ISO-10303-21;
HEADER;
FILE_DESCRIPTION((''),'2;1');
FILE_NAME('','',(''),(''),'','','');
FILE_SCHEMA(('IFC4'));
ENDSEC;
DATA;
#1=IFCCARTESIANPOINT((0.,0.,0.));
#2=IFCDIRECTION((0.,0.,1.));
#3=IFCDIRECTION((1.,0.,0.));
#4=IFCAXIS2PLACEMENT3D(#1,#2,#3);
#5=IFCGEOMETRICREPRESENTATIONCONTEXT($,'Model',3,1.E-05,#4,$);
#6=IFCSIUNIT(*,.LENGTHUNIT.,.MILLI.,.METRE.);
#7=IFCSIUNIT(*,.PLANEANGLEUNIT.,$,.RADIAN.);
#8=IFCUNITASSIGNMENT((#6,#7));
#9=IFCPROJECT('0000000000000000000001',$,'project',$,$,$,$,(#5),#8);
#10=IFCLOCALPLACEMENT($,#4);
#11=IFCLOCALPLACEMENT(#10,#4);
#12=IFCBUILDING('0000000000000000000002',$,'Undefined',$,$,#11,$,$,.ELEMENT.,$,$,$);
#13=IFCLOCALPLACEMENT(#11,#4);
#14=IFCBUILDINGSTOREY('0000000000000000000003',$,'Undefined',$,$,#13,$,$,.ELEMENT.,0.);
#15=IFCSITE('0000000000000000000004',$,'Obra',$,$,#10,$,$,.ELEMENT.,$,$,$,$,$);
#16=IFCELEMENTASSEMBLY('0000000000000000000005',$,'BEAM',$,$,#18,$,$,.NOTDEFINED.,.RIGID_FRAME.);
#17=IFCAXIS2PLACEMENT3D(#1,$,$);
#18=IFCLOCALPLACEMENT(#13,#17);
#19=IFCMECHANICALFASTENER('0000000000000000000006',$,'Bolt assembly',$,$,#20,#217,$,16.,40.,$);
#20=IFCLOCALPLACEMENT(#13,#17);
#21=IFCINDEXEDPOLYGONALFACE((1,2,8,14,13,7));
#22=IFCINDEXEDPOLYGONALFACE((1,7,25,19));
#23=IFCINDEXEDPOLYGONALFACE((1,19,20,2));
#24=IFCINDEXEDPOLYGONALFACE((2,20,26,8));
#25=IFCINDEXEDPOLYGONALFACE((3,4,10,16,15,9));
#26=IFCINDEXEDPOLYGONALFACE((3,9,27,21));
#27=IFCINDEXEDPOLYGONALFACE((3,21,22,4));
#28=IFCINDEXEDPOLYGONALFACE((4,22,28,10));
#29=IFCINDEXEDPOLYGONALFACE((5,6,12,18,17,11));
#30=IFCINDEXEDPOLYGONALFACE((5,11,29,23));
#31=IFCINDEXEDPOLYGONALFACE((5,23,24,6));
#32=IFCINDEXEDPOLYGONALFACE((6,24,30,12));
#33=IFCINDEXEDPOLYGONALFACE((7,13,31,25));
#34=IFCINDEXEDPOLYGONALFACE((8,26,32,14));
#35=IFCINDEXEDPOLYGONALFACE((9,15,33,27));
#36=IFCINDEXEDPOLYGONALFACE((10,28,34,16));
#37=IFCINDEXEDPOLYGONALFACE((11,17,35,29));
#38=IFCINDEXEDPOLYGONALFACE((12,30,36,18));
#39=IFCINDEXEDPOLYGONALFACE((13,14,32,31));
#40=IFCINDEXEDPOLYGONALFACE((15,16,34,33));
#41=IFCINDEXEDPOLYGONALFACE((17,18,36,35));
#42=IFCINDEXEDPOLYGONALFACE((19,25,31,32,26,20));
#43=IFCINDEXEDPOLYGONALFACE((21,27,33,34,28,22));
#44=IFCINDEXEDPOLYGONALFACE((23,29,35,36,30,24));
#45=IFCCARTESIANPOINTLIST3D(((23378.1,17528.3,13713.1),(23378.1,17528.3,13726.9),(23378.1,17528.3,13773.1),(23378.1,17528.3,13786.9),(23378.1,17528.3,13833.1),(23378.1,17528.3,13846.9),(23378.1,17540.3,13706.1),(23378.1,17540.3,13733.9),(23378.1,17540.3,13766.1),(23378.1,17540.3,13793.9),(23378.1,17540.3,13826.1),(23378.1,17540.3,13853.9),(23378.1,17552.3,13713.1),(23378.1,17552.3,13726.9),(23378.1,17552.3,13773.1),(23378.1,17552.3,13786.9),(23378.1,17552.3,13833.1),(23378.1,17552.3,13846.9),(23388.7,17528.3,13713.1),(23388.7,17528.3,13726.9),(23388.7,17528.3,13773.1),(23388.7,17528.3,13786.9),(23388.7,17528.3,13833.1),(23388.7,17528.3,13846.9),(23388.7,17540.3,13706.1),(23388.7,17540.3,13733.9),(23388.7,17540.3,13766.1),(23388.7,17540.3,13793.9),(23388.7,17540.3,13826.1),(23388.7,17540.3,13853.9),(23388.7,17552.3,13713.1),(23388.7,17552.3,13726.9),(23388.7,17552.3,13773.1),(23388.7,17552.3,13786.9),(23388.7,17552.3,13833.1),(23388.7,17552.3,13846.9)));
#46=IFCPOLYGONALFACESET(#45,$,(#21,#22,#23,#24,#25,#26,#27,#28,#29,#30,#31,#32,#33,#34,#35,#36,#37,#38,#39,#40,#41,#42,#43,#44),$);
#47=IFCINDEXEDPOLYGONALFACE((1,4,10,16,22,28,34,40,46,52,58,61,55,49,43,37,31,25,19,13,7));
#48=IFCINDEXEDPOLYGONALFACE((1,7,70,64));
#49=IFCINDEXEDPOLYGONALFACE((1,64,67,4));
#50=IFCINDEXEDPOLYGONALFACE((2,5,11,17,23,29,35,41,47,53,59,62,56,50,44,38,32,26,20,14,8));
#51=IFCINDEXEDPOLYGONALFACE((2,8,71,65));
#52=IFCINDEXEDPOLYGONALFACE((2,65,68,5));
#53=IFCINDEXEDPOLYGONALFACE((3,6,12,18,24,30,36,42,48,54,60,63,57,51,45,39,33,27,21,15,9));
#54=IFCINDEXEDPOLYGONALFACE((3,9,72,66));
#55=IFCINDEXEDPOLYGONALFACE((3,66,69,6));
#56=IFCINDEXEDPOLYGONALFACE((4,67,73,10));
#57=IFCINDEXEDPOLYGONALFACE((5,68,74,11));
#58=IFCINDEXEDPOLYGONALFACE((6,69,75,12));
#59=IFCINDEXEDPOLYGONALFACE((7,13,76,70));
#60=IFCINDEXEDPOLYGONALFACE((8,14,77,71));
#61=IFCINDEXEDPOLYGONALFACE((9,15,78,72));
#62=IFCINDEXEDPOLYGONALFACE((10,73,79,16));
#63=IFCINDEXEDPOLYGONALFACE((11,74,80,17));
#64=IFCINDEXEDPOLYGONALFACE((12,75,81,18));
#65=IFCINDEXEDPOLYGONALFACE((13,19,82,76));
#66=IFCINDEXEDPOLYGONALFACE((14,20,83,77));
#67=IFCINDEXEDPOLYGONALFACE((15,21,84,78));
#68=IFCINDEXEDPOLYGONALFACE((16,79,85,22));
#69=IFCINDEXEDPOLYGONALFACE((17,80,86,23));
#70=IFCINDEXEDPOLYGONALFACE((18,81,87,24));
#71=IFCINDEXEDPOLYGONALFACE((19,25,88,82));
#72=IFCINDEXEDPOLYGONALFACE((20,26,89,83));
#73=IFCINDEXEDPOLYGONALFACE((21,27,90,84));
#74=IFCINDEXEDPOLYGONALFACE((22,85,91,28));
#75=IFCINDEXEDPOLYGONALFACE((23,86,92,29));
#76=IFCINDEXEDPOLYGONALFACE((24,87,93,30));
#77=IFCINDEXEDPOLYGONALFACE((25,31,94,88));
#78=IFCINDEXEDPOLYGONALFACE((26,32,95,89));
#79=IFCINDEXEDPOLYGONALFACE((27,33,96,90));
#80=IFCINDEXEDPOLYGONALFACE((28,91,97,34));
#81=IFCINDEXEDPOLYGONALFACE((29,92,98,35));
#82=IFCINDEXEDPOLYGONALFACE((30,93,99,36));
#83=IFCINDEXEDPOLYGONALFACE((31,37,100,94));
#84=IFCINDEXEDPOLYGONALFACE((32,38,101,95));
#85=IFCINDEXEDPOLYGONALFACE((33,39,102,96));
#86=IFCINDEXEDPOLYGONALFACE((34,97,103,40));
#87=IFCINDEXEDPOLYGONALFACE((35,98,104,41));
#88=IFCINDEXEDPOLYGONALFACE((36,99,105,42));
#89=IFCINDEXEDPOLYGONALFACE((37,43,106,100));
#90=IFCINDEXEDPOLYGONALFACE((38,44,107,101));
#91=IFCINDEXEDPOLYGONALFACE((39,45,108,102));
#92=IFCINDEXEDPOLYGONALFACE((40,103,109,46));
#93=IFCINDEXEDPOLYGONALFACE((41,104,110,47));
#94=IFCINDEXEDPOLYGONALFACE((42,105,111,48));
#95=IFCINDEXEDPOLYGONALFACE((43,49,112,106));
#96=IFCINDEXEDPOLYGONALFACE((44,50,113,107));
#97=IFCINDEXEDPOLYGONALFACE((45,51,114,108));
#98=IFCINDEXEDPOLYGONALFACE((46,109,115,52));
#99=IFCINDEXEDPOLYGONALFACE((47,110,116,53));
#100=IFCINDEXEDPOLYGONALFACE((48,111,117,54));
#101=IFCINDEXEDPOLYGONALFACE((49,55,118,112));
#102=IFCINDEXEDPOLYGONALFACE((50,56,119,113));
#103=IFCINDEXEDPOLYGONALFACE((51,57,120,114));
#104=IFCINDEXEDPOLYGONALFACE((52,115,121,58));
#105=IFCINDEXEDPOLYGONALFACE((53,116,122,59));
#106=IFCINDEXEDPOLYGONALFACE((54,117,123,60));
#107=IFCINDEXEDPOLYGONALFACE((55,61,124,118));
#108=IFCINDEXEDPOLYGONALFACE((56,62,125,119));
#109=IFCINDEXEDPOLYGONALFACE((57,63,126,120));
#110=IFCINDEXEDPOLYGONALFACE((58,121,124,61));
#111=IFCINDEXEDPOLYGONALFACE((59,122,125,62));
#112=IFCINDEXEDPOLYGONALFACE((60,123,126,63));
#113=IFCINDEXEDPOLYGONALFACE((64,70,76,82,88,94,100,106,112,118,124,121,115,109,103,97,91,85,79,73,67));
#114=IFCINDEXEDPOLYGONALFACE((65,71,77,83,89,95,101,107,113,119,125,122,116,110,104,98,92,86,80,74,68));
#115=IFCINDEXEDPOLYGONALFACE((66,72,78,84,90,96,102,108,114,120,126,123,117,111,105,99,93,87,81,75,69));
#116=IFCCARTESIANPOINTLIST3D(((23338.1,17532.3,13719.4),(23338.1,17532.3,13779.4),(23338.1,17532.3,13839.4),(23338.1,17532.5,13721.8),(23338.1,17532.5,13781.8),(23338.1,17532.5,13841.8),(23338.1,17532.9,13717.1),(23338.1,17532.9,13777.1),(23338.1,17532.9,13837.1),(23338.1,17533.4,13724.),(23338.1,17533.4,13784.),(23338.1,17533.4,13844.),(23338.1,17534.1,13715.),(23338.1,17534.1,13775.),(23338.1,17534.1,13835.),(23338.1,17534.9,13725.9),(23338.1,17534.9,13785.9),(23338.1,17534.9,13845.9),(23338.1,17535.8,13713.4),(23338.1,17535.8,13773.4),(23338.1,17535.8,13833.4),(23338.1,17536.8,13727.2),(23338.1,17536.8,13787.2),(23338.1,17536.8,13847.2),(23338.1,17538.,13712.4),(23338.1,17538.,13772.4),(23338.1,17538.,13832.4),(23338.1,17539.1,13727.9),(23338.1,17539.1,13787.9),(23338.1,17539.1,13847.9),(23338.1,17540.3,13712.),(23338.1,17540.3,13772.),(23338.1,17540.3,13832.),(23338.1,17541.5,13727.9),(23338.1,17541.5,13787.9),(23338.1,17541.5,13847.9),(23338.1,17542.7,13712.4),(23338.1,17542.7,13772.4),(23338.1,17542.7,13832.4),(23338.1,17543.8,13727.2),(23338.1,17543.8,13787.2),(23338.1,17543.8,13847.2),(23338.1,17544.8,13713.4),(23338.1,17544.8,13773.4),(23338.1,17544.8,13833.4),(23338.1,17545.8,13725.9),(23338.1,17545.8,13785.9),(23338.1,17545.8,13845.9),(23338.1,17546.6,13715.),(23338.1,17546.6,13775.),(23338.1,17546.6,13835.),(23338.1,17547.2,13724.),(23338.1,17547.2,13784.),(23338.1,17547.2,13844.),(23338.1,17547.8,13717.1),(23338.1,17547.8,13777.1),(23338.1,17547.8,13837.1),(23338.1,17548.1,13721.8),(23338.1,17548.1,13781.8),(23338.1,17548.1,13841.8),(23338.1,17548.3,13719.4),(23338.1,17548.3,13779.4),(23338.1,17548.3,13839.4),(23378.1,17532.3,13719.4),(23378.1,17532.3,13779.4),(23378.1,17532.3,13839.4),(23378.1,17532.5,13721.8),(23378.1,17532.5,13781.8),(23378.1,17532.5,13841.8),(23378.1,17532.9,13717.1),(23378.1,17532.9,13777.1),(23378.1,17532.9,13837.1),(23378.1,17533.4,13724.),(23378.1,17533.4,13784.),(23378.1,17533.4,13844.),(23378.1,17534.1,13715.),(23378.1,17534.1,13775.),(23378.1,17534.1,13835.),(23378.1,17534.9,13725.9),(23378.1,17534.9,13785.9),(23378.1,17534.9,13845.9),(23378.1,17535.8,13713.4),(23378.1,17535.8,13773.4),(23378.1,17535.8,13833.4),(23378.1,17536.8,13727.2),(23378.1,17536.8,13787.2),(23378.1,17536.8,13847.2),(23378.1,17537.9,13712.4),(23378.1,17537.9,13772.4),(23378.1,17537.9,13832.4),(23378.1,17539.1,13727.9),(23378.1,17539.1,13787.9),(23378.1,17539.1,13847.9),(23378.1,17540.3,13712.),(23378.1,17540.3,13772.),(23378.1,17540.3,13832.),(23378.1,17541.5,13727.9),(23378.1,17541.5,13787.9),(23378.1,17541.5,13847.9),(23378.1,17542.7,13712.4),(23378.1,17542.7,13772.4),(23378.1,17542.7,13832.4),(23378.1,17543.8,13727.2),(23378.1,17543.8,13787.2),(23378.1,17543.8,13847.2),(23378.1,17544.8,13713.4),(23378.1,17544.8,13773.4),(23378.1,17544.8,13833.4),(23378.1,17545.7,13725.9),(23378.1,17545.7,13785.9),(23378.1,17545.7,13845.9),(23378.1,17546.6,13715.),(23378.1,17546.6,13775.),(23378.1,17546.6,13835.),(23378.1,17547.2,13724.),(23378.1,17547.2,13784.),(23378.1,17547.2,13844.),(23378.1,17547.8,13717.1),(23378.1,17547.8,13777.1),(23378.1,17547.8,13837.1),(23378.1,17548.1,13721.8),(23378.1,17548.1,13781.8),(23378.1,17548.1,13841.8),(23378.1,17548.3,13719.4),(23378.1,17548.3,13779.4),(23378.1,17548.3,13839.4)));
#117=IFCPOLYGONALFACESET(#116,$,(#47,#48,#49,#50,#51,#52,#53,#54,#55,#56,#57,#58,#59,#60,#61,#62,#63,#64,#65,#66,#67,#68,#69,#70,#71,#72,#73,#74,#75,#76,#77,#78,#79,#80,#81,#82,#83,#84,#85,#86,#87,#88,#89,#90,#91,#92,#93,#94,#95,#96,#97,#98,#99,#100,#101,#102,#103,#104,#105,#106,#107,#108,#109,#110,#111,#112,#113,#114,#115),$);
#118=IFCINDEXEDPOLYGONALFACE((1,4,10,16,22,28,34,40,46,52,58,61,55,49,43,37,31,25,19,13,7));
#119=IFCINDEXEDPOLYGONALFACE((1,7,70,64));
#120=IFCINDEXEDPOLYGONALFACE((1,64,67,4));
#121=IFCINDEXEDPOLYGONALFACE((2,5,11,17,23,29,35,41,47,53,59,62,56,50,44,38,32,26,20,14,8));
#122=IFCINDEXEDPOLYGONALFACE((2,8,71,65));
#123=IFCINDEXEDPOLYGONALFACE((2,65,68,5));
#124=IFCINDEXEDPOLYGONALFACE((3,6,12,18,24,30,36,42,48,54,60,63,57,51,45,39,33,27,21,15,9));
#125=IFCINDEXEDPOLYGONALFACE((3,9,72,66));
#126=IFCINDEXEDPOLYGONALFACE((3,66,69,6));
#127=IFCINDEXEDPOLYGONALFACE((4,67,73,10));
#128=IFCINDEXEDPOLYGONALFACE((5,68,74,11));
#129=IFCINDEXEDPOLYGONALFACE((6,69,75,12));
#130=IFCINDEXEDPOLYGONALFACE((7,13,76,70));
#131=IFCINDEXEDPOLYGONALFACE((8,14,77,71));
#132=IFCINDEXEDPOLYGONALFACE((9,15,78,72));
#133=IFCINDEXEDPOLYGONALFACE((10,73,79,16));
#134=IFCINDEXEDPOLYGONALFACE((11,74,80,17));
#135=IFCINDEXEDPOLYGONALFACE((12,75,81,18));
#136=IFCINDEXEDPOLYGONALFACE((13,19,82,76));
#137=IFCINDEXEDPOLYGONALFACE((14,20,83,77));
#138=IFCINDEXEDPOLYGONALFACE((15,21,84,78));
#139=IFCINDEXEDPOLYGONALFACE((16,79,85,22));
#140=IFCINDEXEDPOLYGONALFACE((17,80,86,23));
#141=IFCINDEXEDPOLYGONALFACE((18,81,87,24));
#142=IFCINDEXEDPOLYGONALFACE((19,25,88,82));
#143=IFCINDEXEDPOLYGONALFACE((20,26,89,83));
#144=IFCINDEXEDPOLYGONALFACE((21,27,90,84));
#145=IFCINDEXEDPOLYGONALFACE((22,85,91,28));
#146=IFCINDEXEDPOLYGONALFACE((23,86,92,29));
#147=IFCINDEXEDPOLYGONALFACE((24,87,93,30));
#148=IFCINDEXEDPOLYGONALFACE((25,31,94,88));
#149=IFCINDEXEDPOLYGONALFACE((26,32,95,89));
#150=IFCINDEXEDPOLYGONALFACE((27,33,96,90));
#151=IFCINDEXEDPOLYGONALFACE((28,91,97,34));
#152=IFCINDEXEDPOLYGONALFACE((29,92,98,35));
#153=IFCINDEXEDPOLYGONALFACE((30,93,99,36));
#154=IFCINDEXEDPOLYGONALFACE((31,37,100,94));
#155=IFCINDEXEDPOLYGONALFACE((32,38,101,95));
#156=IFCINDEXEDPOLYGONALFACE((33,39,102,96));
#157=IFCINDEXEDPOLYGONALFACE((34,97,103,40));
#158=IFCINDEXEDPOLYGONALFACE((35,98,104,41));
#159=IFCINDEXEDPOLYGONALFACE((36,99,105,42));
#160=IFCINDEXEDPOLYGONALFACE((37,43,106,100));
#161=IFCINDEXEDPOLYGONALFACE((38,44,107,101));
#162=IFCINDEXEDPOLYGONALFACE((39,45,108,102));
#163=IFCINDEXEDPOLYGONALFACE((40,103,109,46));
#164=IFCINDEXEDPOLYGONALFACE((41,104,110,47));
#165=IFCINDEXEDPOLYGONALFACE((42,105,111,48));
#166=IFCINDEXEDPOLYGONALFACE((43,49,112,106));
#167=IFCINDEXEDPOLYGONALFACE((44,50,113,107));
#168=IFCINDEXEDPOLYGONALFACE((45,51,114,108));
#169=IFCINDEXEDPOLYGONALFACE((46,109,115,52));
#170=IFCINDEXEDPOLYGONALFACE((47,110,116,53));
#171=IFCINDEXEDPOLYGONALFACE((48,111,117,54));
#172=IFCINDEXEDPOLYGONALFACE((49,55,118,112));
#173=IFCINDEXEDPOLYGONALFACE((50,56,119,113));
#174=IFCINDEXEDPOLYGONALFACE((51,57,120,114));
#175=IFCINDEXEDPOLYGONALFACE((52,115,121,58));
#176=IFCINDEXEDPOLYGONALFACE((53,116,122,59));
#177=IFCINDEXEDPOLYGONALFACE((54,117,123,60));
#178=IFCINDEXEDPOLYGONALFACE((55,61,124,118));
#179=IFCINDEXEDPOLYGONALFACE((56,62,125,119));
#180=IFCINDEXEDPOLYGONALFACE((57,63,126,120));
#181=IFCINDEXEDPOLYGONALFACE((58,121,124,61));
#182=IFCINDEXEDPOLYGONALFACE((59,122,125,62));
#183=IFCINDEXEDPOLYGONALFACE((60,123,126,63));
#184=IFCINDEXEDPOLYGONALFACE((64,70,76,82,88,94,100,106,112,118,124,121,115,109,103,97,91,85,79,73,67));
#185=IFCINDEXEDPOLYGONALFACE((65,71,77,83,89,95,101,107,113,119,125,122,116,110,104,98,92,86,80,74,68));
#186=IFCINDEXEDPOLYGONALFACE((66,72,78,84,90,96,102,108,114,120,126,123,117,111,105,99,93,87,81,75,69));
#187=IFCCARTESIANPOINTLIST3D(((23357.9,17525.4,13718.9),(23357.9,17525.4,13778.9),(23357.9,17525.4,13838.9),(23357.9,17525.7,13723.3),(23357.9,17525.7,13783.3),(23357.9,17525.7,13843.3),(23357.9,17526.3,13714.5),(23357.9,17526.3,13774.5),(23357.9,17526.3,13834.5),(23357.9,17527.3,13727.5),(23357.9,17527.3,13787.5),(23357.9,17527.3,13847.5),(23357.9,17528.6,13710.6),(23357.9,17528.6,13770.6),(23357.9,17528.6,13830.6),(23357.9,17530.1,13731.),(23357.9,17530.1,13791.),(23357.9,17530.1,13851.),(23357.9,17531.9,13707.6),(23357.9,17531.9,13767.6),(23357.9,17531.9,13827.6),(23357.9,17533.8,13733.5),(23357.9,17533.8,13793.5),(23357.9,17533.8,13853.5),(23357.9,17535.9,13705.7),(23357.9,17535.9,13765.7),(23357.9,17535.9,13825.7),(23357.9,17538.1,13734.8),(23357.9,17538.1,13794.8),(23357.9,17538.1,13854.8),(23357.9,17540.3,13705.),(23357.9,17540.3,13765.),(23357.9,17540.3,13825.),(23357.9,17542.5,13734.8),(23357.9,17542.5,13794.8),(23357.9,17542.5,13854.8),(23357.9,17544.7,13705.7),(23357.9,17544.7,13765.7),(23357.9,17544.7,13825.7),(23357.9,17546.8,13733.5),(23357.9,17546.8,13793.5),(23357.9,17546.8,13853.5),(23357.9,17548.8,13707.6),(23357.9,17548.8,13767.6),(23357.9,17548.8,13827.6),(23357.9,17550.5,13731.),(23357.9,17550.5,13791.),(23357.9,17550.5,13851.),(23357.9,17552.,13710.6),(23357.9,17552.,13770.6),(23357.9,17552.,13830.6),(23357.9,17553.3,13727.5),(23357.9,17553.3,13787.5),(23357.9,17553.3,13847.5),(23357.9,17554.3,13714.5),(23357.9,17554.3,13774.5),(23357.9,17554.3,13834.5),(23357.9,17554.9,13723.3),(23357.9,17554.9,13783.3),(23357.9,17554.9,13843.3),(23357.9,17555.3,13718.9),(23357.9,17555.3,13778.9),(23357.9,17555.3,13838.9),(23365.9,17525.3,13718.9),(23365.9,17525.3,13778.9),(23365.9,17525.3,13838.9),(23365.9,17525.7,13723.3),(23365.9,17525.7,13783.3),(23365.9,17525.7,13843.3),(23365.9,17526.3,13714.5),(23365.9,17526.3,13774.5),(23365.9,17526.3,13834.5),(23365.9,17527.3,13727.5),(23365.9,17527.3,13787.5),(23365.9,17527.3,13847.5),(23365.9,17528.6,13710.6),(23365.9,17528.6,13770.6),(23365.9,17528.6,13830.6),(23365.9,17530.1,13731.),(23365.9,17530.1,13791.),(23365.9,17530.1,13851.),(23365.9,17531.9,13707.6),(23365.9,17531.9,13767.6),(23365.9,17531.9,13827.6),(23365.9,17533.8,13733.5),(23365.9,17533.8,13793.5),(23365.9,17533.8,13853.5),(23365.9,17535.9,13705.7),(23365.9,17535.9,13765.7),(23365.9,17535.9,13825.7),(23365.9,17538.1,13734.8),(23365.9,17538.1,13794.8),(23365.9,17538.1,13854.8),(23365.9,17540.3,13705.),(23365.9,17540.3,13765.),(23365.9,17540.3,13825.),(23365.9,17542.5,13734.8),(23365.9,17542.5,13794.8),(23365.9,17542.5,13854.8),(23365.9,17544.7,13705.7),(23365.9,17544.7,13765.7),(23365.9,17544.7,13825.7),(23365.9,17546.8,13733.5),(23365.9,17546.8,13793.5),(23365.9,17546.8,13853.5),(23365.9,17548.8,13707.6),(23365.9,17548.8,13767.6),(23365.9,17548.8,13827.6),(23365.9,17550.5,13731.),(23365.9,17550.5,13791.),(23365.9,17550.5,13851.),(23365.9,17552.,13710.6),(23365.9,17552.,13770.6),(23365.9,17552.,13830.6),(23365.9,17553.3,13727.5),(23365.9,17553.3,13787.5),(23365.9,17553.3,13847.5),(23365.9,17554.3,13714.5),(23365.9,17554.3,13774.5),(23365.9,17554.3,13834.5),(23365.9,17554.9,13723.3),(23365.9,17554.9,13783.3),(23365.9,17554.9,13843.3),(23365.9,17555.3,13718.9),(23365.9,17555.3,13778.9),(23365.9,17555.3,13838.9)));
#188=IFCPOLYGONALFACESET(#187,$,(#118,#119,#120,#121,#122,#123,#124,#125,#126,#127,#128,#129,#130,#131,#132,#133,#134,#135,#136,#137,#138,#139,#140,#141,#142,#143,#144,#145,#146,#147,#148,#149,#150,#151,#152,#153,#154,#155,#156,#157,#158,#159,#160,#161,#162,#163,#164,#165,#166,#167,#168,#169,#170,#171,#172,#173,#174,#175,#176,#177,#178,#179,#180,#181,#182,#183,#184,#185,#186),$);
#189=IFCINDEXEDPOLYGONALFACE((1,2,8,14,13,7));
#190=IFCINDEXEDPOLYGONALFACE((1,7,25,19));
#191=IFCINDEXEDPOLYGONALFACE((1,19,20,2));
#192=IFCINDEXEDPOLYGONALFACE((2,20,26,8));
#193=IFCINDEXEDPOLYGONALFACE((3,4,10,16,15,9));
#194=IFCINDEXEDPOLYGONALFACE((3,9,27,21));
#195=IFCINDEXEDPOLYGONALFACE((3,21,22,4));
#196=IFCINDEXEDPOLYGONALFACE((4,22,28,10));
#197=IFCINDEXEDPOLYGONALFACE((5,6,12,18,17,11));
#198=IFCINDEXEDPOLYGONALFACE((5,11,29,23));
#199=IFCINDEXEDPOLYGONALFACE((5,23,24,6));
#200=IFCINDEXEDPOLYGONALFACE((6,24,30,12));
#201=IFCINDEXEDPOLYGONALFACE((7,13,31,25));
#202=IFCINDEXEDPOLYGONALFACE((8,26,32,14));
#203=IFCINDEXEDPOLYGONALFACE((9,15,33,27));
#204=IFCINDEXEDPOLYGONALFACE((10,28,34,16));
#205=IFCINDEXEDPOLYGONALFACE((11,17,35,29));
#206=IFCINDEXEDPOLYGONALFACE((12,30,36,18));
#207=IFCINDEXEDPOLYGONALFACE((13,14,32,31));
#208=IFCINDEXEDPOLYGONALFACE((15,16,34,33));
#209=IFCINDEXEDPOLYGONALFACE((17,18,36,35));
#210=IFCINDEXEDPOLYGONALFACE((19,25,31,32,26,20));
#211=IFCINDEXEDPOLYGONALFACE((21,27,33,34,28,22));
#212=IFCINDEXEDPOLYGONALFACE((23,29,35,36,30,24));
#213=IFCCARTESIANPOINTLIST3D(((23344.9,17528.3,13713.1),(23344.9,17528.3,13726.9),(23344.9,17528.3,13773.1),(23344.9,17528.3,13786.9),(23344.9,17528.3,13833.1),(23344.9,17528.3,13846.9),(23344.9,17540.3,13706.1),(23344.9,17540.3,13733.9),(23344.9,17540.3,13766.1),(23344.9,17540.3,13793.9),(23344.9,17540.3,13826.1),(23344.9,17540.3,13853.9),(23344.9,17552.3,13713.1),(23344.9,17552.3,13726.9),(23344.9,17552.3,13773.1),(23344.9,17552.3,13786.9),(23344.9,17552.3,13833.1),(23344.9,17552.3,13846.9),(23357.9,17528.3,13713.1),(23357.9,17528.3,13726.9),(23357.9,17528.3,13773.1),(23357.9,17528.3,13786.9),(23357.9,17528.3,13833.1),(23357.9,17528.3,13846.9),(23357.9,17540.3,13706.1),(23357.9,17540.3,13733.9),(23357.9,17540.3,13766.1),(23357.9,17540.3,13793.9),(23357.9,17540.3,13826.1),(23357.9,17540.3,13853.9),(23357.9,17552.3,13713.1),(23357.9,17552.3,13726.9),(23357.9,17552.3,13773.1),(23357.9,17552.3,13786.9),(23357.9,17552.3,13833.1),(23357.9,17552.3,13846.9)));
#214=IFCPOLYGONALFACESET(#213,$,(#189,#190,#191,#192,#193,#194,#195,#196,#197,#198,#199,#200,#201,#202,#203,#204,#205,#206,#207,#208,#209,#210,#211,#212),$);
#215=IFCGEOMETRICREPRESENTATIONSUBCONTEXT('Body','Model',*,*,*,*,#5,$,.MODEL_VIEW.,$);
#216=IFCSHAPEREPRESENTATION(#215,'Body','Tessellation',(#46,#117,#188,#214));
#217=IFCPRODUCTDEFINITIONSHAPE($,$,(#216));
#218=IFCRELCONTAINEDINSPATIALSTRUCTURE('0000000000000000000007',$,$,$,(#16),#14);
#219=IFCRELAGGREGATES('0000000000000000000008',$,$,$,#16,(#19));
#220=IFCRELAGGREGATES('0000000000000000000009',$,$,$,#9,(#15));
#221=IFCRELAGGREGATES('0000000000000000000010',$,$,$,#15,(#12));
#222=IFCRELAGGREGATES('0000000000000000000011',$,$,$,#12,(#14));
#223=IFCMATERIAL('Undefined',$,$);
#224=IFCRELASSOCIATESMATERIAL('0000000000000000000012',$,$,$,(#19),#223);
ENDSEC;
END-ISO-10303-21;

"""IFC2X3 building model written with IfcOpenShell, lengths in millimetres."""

from ifc_helpers import new_model, si_unit, frame, origin_with_axes, origin_2d_with_axis, place, context, subcontext, project, spatial, polyline, circle, outline, extrude, source, transform, mapped, material, element, aggregate, save


model = new_model("IFC2X3")

# Units and contexts
model_context = context("Model", 3, precision=1e-05, world=origin_with_axes())
body_context = subcontext(model_context, "Body", "Model", "MODEL_VIEW")
ifc_project = project(units=[si_unit("LENGTHUNIT", "METRE", prefix="MILLI"), si_unit("PLANEANGLEUNIT", "RADIAN")], contexts=[model_context])

# Site, building, storey
site_placement = place(None, origin_with_axes())
site = spatial("IfcSite", under=ifc_project, at=site_placement, Name="Obra", CompositionType="ELEMENT")
building_placement = place(site_placement, origin_with_axes())
building = spatial("IfcBuilding", under=site, at=building_placement, Name="Undefined", CompositionType="ELEMENT")
storey_placement = place(building_placement, origin_with_axes())
storey = spatial("IfcBuildingStorey", under=building, at=storey_placement, Name="Undefined", CompositionType="ELEMENT", Elevation=0.0)

# Element assembly, mechanical fastener
ifc_material_1 = material(Name="Undefined")
assembly_1_placement = place(storey_placement, origin_with_axes())
assembly_1 = element("IfcElementAssembly", 1, at=assembly_1_placement, inside=storey, Name="BEAM", AssemblyPlace="NOTDEFINED", PredefinedType="RIGID_FRAME")
shared_shape_1 = source(origin_with_axes(), body_context, "Body", "SweptSolid", [
    extrude(outline(polyline([(13.9, 0.0), (6.9, 12.0), (-6.9, 12.0), (-13.9, 0.0), (-6.9, -12.0), (6.9, -12.0), (13.9, 0.0)])), frame((0.0, -13.6, 0.0), z_axis=(0.0, 1.0, 0.0), x_axis=(1.0, 0.0, 0.0)), (0.0, 0.0, 1.0), 10.6),
    extrude(circle(Radius=8.0, at=origin_2d_with_axis()), frame((0.0, -3.1, 0.0), z_axis=(0.0, 1.0, 0.0), x_axis=(1.0, 0.0, 0.0)), (0.0, 0.0, 1.0), 40.0),
    extrude(circle(Radius=15.0, at=origin_2d_with_axis()), frame((0.0, 9.1, 0.0), z_axis=(0.0, 1.0, 0.0), x_axis=(1.0, 0.0, 0.0)), (0.0, 0.0, 1.0), 8.0),
    extrude(outline(polyline([(13.9, 0.0), (6.9, 12.0), (-6.9, 12.0), (-13.9, 0.0), (-6.9, -12.0), (6.9, -12.0), (13.9, 0.0)])), frame((0.0, 17.1, 0.0), z_axis=(0.0, 1.0, 0.0), x_axis=(1.0, 0.0, 0.0)), (0.0, 0.0, 1.0), 13.0),
])
mechanical_fastener_1_placement = place(assembly_1_placement, frame((23375.0, 17490.3, 13879.0), z_axis=(0.000129, 1.0, 0.0), x_axis=(0.0, 0.0, -1.0)))
mechanical_fastener_1 = element("IfcMechanicalFastener", 2, at=mechanical_fastener_1_placement, material=ifc_material_1, Name="Bolt assembly", NominalDiameter=16.0, NominalLength=40.0, context=body_context, shape_type="MappedRepresentation", body=[
    mapped(shared_shape_1, transform((159.0, 0.0, 50.0))),
    mapped(shared_shape_1, transform((99.0, 0.0, 50.0))),
    mapped(shared_shape_1, transform((39.0, 0.0, 50.0))),
])
aggregate(assembly_1, [mechanical_fastener_1])

save(model, "model.ifc")
